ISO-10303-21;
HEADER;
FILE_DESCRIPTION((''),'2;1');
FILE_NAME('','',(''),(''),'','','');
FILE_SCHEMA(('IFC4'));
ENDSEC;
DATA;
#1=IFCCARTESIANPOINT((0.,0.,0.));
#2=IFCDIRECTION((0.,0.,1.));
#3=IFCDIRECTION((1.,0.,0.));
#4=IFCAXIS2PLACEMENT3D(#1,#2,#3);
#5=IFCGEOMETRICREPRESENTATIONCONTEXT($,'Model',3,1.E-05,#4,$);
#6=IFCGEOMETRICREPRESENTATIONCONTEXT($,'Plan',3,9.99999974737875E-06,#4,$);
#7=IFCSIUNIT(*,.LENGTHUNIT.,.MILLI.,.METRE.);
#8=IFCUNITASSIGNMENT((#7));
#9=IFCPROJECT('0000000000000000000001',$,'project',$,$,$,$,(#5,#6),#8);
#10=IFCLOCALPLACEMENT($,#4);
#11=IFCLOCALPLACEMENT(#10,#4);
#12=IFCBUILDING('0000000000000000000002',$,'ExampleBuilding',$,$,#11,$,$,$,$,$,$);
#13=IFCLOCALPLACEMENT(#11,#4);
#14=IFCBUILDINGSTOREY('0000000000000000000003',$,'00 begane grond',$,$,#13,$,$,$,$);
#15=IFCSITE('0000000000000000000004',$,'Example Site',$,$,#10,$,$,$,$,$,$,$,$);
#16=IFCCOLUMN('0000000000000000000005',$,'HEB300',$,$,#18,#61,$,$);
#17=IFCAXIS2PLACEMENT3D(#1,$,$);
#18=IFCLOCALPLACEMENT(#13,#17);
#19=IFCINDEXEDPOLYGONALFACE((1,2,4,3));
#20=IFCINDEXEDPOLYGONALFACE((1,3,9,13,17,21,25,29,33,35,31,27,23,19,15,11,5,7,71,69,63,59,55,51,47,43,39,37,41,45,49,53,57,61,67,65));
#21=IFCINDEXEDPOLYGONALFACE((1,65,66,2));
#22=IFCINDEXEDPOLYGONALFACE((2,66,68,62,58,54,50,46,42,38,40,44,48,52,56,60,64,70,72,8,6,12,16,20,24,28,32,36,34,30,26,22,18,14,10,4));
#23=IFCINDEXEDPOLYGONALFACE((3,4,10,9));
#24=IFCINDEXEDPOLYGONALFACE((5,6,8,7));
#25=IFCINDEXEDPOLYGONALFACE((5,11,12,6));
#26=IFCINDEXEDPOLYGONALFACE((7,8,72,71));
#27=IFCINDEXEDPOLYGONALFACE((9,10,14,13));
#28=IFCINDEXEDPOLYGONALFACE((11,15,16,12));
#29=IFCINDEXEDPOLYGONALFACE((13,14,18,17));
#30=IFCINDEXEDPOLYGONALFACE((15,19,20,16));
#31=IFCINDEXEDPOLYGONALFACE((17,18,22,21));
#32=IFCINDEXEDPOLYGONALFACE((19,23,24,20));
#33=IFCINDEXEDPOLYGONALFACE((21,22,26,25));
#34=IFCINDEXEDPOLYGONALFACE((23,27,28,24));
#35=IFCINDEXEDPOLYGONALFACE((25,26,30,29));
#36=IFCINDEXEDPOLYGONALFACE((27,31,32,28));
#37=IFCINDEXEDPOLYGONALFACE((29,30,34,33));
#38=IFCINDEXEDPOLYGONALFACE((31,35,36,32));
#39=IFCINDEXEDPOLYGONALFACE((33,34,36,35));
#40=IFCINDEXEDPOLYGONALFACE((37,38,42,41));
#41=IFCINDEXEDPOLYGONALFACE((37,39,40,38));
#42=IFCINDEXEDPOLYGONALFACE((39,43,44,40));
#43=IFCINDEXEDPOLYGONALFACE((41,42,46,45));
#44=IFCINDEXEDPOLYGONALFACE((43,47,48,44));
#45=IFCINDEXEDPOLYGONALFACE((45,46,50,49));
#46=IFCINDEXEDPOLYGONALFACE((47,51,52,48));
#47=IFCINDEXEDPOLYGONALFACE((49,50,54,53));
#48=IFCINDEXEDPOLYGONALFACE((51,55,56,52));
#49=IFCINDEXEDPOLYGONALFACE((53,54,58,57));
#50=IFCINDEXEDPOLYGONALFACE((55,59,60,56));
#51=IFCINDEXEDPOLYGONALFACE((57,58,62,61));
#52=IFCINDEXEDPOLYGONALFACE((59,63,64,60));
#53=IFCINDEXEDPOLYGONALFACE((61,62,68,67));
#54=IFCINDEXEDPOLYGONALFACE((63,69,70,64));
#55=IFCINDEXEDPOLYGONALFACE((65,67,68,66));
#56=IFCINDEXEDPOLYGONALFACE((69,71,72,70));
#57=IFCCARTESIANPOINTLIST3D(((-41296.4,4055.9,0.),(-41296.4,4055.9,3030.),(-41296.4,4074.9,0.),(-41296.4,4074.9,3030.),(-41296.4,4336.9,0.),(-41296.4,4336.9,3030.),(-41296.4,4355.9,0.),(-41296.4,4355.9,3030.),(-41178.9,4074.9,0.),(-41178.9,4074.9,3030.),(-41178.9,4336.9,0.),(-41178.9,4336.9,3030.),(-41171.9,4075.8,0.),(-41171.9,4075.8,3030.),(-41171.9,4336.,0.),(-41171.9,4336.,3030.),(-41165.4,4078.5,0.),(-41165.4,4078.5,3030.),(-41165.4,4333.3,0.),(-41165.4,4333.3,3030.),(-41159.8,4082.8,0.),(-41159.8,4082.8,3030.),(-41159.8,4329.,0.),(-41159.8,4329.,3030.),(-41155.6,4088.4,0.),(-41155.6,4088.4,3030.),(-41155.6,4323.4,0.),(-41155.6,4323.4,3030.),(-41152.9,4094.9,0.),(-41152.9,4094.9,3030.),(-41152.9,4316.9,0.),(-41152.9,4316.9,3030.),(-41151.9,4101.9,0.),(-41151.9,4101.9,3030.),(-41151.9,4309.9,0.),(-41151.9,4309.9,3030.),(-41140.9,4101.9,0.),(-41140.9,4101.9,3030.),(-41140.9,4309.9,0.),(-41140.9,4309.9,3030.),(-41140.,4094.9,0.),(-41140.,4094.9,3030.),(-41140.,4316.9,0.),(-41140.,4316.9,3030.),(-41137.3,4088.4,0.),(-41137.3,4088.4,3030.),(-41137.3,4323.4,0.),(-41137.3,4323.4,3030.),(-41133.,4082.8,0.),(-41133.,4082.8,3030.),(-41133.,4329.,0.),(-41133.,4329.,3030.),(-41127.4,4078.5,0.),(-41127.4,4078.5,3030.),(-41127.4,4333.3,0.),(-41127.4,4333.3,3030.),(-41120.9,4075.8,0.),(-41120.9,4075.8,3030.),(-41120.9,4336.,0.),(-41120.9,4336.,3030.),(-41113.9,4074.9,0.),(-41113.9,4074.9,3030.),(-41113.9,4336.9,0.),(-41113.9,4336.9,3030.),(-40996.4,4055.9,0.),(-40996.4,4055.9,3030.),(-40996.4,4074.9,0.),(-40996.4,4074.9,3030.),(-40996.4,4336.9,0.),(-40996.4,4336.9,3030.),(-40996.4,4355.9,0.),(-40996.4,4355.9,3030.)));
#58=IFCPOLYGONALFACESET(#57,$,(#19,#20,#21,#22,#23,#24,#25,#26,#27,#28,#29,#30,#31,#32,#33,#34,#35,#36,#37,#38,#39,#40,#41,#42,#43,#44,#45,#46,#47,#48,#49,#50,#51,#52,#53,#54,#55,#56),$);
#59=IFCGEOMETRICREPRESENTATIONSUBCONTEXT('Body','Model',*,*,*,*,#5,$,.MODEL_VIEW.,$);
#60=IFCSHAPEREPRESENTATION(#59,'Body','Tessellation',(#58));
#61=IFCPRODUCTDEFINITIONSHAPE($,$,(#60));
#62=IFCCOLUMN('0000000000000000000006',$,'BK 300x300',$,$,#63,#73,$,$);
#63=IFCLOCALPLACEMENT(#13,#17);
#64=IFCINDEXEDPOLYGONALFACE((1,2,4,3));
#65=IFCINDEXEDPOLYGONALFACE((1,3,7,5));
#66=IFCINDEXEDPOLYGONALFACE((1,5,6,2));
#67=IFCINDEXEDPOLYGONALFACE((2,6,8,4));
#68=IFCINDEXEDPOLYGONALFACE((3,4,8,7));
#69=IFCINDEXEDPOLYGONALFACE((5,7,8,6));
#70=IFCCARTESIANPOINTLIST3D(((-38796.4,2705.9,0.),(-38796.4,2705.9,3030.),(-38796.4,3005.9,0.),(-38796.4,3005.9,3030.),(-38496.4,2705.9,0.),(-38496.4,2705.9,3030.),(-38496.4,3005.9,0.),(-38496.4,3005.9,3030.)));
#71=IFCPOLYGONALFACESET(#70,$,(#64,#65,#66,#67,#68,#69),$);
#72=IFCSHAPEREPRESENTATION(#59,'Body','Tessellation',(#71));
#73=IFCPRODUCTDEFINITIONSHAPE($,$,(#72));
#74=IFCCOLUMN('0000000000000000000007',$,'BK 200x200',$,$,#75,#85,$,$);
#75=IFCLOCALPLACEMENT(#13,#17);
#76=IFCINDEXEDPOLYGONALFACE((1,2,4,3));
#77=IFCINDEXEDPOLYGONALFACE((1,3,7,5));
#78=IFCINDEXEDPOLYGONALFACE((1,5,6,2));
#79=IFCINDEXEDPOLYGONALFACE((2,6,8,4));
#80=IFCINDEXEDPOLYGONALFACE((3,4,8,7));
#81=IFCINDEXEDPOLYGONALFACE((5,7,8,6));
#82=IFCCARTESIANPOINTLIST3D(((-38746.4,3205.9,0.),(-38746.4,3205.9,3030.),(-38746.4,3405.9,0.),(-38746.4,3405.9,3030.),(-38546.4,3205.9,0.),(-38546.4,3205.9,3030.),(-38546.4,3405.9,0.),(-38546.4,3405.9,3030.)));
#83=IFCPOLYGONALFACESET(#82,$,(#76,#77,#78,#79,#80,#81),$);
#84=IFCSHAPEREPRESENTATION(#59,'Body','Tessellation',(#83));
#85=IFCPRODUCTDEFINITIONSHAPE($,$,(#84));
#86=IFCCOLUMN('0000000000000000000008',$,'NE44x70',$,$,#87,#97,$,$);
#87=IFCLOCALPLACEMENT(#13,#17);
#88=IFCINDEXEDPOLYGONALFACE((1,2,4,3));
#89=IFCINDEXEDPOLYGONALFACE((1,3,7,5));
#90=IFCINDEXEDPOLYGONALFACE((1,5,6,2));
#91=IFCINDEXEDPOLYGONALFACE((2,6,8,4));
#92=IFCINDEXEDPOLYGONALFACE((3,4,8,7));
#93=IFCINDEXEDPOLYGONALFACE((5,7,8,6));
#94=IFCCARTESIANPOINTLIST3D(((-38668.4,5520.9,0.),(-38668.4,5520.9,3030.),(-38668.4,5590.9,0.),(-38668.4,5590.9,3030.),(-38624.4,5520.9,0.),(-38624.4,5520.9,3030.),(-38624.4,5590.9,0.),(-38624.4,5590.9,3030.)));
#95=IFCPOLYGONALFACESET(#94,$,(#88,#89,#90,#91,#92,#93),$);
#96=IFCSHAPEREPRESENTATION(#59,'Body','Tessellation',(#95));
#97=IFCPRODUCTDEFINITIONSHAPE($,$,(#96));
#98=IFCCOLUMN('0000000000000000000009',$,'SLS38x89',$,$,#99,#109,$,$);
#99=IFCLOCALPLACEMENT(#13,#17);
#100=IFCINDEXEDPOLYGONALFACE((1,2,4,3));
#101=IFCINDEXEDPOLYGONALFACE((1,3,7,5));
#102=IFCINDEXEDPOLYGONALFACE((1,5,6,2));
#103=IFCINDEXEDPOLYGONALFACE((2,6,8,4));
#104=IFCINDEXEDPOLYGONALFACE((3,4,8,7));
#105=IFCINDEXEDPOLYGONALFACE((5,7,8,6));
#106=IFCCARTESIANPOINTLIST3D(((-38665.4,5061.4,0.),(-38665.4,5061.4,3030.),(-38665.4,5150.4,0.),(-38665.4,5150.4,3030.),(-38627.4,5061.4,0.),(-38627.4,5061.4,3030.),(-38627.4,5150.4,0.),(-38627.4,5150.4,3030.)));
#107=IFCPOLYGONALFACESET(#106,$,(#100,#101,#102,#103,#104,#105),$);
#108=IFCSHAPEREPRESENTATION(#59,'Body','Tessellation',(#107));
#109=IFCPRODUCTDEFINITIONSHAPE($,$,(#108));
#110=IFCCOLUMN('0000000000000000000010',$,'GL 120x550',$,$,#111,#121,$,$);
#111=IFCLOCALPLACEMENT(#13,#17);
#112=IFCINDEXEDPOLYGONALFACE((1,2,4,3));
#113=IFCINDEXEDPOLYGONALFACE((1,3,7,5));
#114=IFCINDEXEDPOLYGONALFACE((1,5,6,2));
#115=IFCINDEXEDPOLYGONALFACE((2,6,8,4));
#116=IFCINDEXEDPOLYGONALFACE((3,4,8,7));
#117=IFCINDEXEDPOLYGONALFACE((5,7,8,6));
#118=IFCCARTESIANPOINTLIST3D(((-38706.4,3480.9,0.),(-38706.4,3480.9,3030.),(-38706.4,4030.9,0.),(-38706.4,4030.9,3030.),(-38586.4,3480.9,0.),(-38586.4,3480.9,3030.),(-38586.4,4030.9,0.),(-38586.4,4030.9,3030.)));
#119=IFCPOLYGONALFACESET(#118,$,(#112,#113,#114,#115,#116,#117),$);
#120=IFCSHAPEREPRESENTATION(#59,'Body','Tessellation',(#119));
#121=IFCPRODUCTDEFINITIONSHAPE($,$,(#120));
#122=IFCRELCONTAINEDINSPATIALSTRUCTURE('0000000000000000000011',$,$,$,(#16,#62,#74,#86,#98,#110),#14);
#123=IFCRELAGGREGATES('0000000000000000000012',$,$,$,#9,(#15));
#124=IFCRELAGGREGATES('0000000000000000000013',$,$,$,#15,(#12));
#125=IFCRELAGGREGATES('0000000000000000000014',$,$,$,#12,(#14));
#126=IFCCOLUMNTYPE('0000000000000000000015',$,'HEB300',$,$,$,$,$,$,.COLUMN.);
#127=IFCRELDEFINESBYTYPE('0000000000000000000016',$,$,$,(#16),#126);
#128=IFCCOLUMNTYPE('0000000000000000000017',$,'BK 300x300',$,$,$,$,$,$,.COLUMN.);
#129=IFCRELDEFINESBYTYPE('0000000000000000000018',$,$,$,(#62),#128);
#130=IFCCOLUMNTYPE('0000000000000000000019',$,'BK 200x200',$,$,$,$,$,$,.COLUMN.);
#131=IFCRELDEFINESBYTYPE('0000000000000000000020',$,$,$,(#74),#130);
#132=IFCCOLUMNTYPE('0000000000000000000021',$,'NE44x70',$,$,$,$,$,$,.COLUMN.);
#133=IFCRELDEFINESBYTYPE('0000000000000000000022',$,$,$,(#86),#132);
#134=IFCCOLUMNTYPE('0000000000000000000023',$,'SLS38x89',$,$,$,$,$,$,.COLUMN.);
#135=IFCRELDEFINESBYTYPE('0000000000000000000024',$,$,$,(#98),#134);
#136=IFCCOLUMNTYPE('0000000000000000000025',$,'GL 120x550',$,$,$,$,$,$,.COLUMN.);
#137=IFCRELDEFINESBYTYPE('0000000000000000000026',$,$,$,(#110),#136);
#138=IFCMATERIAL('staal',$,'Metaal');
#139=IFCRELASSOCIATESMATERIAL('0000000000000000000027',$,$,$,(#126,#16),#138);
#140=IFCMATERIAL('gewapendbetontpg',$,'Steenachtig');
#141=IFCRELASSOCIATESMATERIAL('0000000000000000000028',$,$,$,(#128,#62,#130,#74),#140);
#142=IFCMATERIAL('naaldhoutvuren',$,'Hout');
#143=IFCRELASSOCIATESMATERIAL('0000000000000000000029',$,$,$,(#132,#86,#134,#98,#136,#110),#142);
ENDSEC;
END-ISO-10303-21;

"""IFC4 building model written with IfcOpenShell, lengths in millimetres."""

from ifc_helpers import new_model, si_unit, frame, origin_with_axes, place, context, subcontext, project, spatial, rectangle, i_section, extrude, material, material_profile, profile_set, profile_usage, type_object, element, save


model = new_model("IFC4")

# Units and contexts
model_context = context("Model", 3, precision=1e-05, world=origin_with_axes())
plan_context = context("Plan", 3, precision=9.99999974737875e-06, world=origin_with_axes())
body_context = subcontext(model_context, "Body", "Model", "MODEL_VIEW")
ifc_project = project(units=[si_unit("LENGTHUNIT", "METRE", prefix="MILLI")], contexts=[model_context, plan_context])

# Site, building, storey
site_placement = place(None, frame((0.0, 0.0, 0.0), z_axis=(0.0, 0.0, 1.0), x_axis=(1.0, 0.0, 0.0)))
site = spatial("IfcSite", under=ifc_project, at=site_placement, Name="Example Site")
building_placement = place(site_placement, frame((0.0, 0.0, 0.0), z_axis=(0.0, 0.0, 1.0), x_axis=(1.0, 0.0, 0.0)))
building = spatial("IfcBuilding", under=site, at=building_placement, Name="ExampleBuilding")
storey_placement = place(building_placement, frame((0.0, 0.0, 0.0), z_axis=(0.0, 0.0, 1.0), x_axis=(1.0, 0.0, 0.0)))
storey = spatial("IfcBuildingStorey", under=building, at=storey_placement, Name="00 begane grond")

# Columns
ifc_material_1 = material(Name="staal", Category="Metaal")
ifc_material_profile_1 = material_profile(ifc_material_1, i_section(OverallWidth=300.0, OverallDepth=300.0, WebThickness=11.0, FlangeThickness=19.0, FilletRadius=27.0))
ifc_profile_set_1 = profile_set([ifc_material_profile_1], Name="staal")
ifc_profile_usage_1 = profile_usage(ifc_profile_set_1, cardinal=5)
column_type_1 = type_object("IfcColumnType", Name="HEB300", PredefinedType="COLUMN", material=ifc_profile_set_1)
column_1_placement = place(storey_placement, frame((-41146.4, 4205.9, 0.0), z_axis=(0.0, 0.0, 1.0), x_axis=(1.0, 0.0, 0.0)))
element("IfcColumn", 1, at=column_1_placement, inside=storey, type_object=column_type_1, material=ifc_profile_usage_1, Name="HEB300", context=body_context, shape_type="SweptSolid", body=[
    extrude(i_section(OverallWidth=300.0, OverallDepth=300.0, WebThickness=11.0, FlangeThickness=19.0, FilletRadius=27.0), origin_with_axes(), (0.0, 0.0, 1.0), 3030.0),
])
ifc_material_2 = material(Name="gewapendbetontpg", Category="Steenachtig")
ifc_material_profile_2 = material_profile(ifc_material_2, rectangle(XDim=300.0, YDim=300.0))
ifc_profile_set_2 = profile_set([ifc_material_profile_2], Name="gewapendbetontpg")
ifc_profile_usage_2 = profile_usage(ifc_profile_set_2)
column_type_2 = type_object("IfcColumnType", Name="BK 300x300", PredefinedType="COLUMN", material=ifc_profile_set_2)
column_2_placement = place(storey_placement, frame((-38646.4, 2855.9, 0.0), z_axis=(0.0, 0.0, 1.0), x_axis=(1.0, 0.0, 0.0)))
element("IfcColumn", 2, at=column_2_placement, inside=storey, type_object=column_type_2, material=ifc_profile_usage_2, Name="BK 300x300", context=body_context, shape_type="SweptSolid", body=[
    extrude(rectangle(XDim=300.0, YDim=300.0), origin_with_axes(), (0.0, 0.0, 1.0), 3030.0),
])
ifc_material_profile_3 = material_profile(ifc_material_2, rectangle(XDim=200.0, YDim=200.0))
ifc_profile_set_3 = profile_set([ifc_material_profile_3], Name="gewapendbetontpg")
ifc_profile_usage_3 = profile_usage(ifc_profile_set_3)
column_type_3 = type_object("IfcColumnType", Name="BK 200x200", PredefinedType="COLUMN", material=ifc_profile_set_3)
column_3_placement = place(storey_placement, frame((-38646.4, 3305.9, 0.0), z_axis=(0.0, 0.0, 1.0), x_axis=(1.0, 0.0, 0.0)))
element("IfcColumn", 3, at=column_3_placement, inside=storey, type_object=column_type_3, material=ifc_profile_usage_3, Name="BK 200x200", context=body_context, shape_type="SweptSolid", body=[
    extrude(rectangle(XDim=200.0, YDim=200.0), origin_with_axes(), (0.0, 0.0, 1.0), 3030.0),
])
ifc_material_3 = material(Name="naaldhoutvuren", Category="Hout")
ifc_material_profile_4 = material_profile(ifc_material_3, rectangle(XDim=44.0, YDim=70.0, kind="CURVE"))
ifc_profile_set_4 = profile_set([ifc_material_profile_4], Name="naaldhoutvuren")
ifc_profile_usage_4 = profile_usage(ifc_profile_set_4)
column_type_4 = type_object("IfcColumnType", Name="NE44x70", PredefinedType="COLUMN", material=ifc_profile_set_4)
column_4_placement = place(storey_placement, frame((-38646.4, 5555.9, 0.0), z_axis=(0.0, 0.0, 1.0), x_axis=(1.0, 0.0, 0.0)))
element("IfcColumn", 4, at=column_4_placement, inside=storey, type_object=column_type_4, material=ifc_profile_usage_4, Name="NE44x70", context=body_context, shape_type="SweptSolid", body=[
    extrude(rectangle(XDim=44.0, YDim=70.0, kind="CURVE"), origin_with_axes(), (0.0, 0.0, 1.0), 3030.0),
])
ifc_material_profile_5 = material_profile(ifc_material_3, rectangle(XDim=38.0, YDim=89.0, kind="CURVE"))
ifc_profile_set_5 = profile_set([ifc_material_profile_5], Name="naaldhoutvuren")
ifc_profile_usage_5 = profile_usage(ifc_profile_set_5)
column_type_5 = type_object("IfcColumnType", Name="SLS38x89", PredefinedType="COLUMN", material=ifc_profile_set_5)
column_5_placement = place(storey_placement, frame((-38646.4, 5105.9, 0.0), z_axis=(0.0, 0.0, 1.0), x_axis=(1.0, 0.0, 0.0)))
element("IfcColumn", 5, at=column_5_placement, inside=storey, type_object=column_type_5, material=ifc_profile_usage_5, Name="SLS38x89", context=body_context, shape_type="SweptSolid", body=[
    extrude(rectangle(XDim=38.0, YDim=89.0, kind="CURVE"), origin_with_axes(), (0.0, 0.0, 1.0), 3030.0),
])
ifc_material_profile_6 = material_profile(ifc_material_3, rectangle(XDim=120.0, YDim=550.0, kind="CURVE"))
ifc_profile_set_6 = profile_set([ifc_material_profile_6], Name="naaldhoutvuren")
ifc_profile_usage_6 = profile_usage(ifc_profile_set_6)
column_type_6 = type_object("IfcColumnType", Name="GL 120x550", PredefinedType="COLUMN", material=ifc_profile_set_6)
column_6_placement = place(storey_placement, frame((-38646.4, 3755.9, 0.0), z_axis=(0.0, 0.0, 1.0), x_axis=(1.0, 0.0, 0.0)))
element("IfcColumn", 6, at=column_6_placement, inside=storey, type_object=column_type_6, material=ifc_profile_usage_6, Name="GL 120x550", context=body_context, shape_type="SweptSolid", body=[
    extrude(rectangle(XDim=120.0, YDim=550.0, kind="CURVE"), origin_with_axes(), (0.0, 0.0, 1.0), 3030.0),
])

save(model, "model.ifc")
